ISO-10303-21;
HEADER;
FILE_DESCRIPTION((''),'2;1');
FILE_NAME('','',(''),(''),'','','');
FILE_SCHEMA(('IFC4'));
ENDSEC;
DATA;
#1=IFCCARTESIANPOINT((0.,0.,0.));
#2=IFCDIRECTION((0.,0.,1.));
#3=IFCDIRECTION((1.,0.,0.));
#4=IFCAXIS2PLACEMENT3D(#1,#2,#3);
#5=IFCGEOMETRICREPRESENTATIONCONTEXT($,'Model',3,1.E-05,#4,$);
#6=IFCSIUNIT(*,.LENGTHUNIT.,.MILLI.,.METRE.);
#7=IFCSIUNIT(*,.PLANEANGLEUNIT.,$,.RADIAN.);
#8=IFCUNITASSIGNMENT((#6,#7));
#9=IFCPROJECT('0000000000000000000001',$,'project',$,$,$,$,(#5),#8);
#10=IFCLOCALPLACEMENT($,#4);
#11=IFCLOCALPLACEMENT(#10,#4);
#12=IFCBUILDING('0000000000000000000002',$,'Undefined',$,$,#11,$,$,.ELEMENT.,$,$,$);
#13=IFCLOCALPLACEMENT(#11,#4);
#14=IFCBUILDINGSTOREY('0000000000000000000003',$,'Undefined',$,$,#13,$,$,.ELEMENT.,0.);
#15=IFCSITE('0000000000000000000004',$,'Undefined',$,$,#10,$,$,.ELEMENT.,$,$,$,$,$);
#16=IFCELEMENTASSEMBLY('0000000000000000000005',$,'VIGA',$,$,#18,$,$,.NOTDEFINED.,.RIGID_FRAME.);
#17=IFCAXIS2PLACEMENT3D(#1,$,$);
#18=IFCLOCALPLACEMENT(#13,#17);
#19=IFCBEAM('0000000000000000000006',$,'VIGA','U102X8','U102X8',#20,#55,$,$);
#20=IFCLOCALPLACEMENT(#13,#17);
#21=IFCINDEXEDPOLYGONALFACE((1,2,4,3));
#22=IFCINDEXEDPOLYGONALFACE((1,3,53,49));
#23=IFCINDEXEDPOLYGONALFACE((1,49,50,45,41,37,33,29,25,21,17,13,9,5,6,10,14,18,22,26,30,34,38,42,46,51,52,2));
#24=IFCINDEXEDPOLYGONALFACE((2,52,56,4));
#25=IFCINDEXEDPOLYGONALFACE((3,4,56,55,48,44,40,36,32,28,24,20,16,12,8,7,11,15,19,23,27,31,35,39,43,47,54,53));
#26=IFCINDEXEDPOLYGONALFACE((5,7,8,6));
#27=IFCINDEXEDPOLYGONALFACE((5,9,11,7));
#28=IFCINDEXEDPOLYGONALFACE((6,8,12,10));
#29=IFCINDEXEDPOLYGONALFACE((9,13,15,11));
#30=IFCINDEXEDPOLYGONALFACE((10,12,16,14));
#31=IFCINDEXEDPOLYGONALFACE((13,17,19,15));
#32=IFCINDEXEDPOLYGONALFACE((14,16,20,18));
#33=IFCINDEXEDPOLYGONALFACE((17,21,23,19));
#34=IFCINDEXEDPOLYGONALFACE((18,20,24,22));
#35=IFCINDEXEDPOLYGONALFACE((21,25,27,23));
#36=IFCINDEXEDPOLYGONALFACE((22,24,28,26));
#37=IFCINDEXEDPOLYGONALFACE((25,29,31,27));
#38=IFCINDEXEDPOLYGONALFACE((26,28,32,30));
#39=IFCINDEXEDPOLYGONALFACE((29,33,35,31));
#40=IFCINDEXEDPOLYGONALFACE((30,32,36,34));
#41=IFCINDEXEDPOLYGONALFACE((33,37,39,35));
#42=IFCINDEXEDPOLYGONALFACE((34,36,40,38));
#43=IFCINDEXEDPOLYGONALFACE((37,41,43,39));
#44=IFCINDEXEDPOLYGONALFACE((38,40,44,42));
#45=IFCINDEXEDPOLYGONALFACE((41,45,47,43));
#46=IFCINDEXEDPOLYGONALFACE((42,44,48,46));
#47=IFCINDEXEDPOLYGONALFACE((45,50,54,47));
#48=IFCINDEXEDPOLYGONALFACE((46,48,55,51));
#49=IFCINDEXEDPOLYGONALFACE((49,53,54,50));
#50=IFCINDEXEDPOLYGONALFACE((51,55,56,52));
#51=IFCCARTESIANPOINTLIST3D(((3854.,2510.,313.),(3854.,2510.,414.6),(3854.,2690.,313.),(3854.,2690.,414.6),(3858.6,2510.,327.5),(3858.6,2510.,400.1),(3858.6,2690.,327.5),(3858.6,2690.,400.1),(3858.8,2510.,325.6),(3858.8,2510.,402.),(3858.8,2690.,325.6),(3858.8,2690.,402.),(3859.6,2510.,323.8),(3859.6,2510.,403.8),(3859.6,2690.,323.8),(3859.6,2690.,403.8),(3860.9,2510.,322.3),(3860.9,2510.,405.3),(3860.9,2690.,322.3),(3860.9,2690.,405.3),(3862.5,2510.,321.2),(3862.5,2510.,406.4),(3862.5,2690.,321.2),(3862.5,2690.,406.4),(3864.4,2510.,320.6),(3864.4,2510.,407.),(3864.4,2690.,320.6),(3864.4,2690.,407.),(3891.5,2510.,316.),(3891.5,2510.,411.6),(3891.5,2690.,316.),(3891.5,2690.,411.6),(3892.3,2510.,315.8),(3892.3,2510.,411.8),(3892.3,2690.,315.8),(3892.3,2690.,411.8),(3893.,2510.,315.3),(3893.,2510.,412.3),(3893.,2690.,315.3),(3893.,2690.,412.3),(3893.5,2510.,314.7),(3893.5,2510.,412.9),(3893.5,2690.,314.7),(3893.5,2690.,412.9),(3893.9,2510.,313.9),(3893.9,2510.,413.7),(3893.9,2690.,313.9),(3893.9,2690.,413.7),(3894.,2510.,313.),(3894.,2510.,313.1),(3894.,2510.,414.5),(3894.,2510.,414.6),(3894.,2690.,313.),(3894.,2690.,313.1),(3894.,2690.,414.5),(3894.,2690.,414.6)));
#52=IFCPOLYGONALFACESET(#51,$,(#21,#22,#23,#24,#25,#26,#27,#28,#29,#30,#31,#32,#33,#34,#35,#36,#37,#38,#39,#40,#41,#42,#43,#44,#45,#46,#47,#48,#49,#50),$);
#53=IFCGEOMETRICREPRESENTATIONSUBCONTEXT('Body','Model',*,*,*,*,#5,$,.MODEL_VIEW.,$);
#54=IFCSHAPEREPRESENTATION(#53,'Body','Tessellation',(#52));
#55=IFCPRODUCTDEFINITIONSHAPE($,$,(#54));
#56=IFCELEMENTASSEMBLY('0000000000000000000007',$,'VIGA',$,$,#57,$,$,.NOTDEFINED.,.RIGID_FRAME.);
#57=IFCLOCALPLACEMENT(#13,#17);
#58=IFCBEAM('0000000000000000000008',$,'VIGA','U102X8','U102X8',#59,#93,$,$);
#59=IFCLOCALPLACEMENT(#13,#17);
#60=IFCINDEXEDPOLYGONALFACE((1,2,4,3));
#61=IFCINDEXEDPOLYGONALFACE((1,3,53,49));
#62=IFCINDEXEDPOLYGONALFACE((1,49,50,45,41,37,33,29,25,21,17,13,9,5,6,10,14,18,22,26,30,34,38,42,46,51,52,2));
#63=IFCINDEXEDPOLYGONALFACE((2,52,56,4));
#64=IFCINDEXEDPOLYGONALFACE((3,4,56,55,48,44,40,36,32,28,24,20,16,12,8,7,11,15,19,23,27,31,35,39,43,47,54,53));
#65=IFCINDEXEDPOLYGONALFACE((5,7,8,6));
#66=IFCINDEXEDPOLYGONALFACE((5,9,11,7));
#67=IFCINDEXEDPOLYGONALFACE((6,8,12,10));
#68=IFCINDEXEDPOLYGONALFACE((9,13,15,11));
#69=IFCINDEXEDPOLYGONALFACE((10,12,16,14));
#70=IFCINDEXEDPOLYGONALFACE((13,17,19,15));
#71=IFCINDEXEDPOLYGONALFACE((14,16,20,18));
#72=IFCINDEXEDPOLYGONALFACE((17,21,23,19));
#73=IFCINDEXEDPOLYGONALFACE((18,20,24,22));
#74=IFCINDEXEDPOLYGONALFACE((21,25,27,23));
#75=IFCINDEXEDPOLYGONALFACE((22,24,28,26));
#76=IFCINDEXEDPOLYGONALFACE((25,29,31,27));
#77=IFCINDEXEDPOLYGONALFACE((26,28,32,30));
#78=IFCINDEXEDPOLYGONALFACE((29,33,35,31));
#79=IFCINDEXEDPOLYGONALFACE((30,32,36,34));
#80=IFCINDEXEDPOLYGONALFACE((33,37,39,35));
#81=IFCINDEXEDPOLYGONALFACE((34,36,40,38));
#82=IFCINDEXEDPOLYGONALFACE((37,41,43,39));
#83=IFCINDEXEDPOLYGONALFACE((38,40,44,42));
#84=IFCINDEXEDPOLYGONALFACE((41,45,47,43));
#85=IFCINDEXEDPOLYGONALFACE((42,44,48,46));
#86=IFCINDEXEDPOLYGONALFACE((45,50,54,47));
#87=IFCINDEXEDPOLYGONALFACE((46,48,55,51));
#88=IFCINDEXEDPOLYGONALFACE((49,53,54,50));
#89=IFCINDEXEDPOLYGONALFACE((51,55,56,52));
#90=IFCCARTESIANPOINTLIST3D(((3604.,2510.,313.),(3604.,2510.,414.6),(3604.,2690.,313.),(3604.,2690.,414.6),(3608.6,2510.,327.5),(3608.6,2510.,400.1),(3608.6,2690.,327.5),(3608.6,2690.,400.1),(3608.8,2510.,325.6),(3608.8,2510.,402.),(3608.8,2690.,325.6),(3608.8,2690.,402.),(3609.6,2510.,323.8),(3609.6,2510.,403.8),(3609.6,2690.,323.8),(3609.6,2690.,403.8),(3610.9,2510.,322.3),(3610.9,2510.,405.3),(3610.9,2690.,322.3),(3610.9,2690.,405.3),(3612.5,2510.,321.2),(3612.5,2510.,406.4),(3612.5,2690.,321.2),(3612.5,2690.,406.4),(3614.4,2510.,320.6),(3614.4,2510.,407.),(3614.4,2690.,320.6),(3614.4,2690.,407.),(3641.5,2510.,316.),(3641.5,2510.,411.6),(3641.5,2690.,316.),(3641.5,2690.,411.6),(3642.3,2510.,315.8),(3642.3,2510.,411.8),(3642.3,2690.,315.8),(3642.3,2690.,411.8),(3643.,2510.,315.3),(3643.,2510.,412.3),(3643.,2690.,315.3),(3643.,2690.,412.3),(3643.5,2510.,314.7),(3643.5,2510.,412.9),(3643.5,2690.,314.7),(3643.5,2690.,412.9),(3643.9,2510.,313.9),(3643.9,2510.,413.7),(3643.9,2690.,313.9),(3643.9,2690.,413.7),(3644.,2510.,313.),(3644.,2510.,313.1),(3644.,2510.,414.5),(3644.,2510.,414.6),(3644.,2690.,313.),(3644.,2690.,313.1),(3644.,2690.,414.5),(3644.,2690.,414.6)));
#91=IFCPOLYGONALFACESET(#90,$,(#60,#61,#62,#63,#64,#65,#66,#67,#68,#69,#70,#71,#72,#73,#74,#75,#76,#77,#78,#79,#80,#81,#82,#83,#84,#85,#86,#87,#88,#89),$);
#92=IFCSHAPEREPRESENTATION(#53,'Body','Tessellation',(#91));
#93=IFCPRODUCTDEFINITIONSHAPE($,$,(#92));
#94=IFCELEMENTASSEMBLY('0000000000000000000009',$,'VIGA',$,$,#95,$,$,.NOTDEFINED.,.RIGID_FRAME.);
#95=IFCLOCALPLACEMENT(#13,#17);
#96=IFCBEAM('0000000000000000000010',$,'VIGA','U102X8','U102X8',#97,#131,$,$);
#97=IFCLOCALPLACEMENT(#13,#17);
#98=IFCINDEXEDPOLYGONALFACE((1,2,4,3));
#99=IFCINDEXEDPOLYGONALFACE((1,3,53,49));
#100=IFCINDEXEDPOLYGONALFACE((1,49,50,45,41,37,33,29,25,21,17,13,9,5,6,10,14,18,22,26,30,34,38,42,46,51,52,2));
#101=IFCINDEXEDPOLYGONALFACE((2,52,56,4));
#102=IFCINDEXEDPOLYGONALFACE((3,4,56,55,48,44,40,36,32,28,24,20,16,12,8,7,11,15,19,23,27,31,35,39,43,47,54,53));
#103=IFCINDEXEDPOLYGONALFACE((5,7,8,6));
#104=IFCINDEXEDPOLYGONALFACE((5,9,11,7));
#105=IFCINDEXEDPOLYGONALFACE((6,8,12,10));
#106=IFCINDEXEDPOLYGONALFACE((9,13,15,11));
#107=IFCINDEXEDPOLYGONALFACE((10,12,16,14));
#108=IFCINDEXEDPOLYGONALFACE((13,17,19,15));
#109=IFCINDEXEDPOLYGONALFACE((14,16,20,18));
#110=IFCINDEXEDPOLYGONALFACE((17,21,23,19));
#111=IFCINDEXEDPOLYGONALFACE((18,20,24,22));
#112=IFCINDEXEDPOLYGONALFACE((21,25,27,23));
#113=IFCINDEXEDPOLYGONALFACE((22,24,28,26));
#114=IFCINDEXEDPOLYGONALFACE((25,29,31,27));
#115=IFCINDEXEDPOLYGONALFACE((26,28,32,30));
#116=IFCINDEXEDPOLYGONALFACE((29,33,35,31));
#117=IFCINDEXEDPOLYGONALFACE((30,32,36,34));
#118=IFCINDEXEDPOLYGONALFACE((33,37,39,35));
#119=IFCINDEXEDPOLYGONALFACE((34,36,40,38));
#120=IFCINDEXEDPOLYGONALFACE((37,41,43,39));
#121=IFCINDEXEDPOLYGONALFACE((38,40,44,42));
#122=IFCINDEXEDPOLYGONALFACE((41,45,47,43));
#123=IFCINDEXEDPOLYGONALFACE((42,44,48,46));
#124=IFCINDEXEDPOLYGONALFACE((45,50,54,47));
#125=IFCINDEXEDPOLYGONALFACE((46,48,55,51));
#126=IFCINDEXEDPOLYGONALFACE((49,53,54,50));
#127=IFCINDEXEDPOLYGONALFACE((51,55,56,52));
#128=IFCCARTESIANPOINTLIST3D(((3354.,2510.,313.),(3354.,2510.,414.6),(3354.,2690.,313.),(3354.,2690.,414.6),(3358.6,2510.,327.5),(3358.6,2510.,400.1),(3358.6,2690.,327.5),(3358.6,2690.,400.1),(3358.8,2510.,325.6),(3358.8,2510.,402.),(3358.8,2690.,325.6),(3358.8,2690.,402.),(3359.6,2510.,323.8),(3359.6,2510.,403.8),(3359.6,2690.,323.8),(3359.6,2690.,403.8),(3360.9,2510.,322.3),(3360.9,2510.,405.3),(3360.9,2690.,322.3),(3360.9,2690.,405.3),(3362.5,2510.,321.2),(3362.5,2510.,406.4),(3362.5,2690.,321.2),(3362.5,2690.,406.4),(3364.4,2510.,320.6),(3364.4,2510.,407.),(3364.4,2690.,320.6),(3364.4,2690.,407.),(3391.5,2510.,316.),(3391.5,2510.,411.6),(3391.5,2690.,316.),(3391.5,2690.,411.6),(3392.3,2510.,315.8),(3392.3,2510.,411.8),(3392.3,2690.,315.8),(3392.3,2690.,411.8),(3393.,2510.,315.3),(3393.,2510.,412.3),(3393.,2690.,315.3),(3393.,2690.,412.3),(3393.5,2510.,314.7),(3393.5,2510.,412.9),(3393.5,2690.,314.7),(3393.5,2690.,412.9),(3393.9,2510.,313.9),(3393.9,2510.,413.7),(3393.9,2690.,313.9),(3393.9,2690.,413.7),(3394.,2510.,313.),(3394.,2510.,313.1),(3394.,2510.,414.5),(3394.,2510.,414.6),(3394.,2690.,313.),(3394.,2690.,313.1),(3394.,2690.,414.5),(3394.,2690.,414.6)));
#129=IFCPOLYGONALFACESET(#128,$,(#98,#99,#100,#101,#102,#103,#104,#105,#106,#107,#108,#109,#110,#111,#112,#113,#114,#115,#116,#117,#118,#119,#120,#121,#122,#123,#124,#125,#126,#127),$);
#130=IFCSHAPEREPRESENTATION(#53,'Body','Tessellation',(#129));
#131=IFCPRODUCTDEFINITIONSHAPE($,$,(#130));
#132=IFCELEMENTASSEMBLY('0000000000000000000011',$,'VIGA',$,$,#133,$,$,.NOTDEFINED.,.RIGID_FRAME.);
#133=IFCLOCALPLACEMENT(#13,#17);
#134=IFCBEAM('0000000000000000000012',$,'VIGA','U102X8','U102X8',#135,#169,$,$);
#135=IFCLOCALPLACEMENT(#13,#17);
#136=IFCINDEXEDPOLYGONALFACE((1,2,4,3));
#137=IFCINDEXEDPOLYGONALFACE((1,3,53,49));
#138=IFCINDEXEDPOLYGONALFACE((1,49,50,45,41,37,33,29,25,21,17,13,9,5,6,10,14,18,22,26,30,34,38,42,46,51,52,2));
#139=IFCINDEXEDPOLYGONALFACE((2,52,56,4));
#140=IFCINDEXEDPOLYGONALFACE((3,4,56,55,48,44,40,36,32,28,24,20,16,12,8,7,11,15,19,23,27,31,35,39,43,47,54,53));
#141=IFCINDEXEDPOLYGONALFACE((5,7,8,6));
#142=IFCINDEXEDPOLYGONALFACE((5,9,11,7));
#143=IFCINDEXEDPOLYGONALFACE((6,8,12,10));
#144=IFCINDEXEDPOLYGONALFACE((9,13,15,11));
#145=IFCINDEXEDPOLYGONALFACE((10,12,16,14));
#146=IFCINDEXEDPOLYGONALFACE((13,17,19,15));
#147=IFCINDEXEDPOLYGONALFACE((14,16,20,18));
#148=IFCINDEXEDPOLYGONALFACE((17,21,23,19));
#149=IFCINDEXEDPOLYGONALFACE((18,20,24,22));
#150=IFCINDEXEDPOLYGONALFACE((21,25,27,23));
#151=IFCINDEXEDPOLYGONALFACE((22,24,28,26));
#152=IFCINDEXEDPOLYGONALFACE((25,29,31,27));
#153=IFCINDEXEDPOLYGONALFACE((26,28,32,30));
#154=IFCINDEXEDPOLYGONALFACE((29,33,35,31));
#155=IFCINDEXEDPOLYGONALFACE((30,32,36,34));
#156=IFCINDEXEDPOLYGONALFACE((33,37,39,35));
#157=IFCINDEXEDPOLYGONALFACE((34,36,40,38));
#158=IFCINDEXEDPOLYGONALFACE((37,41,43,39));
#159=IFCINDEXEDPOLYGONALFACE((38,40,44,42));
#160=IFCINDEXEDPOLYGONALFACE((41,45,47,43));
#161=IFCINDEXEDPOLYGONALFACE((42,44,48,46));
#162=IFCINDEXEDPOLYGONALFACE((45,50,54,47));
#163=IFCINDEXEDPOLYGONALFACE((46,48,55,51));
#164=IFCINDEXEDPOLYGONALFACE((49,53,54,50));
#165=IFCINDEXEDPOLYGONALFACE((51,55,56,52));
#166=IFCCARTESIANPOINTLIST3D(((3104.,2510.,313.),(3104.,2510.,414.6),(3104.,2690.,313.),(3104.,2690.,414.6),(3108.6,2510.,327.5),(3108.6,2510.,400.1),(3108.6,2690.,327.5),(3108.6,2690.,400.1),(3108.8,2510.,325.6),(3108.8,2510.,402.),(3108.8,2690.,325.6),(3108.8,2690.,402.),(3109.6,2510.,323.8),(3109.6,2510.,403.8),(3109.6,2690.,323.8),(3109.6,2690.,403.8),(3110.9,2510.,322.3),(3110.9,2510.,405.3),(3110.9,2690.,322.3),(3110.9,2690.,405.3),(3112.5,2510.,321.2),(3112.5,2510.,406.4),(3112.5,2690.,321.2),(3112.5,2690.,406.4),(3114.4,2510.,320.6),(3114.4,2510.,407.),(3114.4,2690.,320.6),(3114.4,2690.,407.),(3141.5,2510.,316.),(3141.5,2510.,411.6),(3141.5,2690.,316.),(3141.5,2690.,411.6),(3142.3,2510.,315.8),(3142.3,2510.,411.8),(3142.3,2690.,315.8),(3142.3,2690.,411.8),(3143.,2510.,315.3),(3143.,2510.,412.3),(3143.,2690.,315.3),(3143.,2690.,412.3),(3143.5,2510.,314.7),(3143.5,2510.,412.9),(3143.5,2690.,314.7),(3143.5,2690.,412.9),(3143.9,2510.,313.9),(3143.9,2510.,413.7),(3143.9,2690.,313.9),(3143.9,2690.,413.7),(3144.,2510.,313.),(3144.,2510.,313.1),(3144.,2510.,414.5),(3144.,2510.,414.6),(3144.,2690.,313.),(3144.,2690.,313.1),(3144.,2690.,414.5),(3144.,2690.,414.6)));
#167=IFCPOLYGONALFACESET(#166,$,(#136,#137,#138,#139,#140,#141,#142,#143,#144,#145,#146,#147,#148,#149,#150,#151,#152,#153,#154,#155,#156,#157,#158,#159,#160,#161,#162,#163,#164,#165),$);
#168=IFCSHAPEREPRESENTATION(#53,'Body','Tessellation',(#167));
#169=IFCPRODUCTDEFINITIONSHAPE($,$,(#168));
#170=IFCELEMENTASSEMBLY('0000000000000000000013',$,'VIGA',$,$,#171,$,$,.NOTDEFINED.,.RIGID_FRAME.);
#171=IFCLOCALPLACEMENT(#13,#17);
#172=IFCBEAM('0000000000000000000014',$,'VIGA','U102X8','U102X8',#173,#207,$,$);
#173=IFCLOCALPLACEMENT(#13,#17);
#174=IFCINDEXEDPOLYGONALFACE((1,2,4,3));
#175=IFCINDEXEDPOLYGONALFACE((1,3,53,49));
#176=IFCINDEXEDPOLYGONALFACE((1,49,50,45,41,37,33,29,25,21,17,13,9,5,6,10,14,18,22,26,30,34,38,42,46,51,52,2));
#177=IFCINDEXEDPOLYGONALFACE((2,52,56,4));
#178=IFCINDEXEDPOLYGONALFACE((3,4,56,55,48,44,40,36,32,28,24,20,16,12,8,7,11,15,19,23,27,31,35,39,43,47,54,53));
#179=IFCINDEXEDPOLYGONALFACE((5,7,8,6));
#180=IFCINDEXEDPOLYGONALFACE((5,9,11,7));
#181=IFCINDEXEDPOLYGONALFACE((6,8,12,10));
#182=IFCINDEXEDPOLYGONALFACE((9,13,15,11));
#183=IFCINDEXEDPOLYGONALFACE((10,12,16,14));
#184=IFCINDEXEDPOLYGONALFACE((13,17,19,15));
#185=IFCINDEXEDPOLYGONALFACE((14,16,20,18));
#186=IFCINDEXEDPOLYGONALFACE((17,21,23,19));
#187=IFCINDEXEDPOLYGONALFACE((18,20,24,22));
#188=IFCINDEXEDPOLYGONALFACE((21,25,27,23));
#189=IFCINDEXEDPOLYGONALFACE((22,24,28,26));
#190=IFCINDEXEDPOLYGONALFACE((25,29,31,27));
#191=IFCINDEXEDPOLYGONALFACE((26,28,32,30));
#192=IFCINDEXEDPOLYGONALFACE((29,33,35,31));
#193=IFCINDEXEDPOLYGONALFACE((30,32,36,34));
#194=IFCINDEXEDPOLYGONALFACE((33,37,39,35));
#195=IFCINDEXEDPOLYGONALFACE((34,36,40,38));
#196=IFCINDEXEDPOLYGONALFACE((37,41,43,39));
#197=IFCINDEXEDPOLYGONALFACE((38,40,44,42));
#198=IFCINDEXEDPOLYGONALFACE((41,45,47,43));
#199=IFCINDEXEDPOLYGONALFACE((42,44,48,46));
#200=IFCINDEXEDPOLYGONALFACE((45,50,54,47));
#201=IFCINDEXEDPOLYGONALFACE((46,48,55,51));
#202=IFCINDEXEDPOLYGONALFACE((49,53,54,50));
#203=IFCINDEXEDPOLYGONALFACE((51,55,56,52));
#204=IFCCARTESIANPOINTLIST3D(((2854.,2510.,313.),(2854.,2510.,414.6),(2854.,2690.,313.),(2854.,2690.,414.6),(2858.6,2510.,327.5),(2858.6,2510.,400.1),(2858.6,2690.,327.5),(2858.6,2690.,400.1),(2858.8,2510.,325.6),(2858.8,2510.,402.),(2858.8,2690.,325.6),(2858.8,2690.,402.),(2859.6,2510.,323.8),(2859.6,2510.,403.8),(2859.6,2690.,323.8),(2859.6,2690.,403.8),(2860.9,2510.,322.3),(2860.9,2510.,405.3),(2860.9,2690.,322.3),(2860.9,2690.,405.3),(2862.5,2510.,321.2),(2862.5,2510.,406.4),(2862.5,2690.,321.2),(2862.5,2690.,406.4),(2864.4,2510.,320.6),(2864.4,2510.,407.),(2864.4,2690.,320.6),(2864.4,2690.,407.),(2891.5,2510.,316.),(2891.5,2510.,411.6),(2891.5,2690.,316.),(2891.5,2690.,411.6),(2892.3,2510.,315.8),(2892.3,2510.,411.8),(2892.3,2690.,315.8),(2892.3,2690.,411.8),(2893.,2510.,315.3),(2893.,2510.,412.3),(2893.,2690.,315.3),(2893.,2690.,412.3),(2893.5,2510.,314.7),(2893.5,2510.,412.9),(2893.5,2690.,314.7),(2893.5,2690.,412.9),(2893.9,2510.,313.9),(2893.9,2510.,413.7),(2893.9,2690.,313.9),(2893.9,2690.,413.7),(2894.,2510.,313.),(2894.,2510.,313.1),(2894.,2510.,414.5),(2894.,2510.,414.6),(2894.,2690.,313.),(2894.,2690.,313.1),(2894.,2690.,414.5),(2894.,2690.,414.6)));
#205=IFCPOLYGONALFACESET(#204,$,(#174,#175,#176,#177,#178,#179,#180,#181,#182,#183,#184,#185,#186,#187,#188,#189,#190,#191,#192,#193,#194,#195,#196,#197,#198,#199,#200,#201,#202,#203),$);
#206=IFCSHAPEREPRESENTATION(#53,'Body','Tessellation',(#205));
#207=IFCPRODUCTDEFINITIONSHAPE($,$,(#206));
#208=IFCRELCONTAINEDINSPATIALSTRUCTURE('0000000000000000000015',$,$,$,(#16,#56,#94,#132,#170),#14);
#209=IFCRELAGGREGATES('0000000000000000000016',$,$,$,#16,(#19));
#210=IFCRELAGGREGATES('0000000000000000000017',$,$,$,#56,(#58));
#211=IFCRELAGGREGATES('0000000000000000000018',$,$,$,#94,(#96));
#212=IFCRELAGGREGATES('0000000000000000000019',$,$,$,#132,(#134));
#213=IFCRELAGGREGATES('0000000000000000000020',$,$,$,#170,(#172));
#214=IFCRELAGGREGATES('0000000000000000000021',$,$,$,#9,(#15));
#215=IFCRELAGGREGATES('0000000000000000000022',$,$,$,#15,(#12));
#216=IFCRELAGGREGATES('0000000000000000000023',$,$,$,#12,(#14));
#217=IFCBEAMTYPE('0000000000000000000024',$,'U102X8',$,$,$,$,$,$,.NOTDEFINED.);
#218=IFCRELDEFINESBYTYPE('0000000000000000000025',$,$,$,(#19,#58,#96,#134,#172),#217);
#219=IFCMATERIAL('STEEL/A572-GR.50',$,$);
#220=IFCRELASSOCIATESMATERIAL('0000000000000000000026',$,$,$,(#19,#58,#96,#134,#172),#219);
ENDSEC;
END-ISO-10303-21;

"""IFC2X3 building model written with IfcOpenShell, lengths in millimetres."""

from ifc_helpers import new_model, si_unit, frame, origin_with_axes, origin_2d_with_axis, place, context, subcontext, project, spatial, u_section, extrude, material, type_object, element, aggregate, save


model = new_model("IFC2X3")

# Units and contexts
model_context = context("Model", 3, precision=1e-05, world=origin_with_axes())
body_context = subcontext(model_context, "Body", "Model", "MODEL_VIEW")
ifc_project = project(units=[si_unit("LENGTHUNIT", "METRE", prefix="MILLI"), si_unit("PLANEANGLEUNIT", "RADIAN")], contexts=[model_context])

# Site, building, storey
site_placement = place(None, origin_with_axes())
site = spatial("IfcSite", under=ifc_project, at=site_placement, Name="Undefined", CompositionType="ELEMENT")
building_placement = place(site_placement, origin_with_axes())
building = spatial("IfcBuilding", under=site, at=building_placement, Name="Undefined", CompositionType="ELEMENT")
storey_placement = place(building_placement, origin_with_axes())
storey = spatial("IfcBuildingStorey", under=building, at=storey_placement, Name="Undefined", CompositionType="ELEMENT", Elevation=0.0)

# Element assemblies, beams
ifc_material = material(Name="STEEL/A572-GR.50")
beam_type = type_object("IfcBeamType", Name="U102X8", PredefinedType="NOTDEFINED")
assembly_1_placement = place(storey_placement, origin_with_axes())
assembly_1 = element("IfcElementAssembly", 1, at=assembly_1_placement, inside=storey, Name="VIGA", AssemblyPlace="NOTDEFINED", PredefinedType="RIGID_FRAME")
beam_1_placement = place(assembly_1_placement, frame((3874.0, 2510.0, 363.8), z_axis=(0.0, 0.0, 1.0), x_axis=(0.0, 1.0, 0.0)))
beam_1 = element("IfcBeam", 2, at=beam_1_placement, type_object=beam_type, material=ifc_material, Name="VIGA", Description="U102X8", ObjectType="U102X8", context=body_context, shape_type="SweptSolid", body=[
    extrude(u_section(Depth=101.6, FlangeWidth=40.0, WebThickness=4.6, FlangeThickness=6.0, FilletRadius=7.0, EdgeRadius=3.0, FlangeSlope=0.16839, at=origin_2d_with_axis()), frame((180.0, 0.0, 0.0), z_axis=(-1.0, 0.0, 0.0), x_axis=(0.0, -1.0, 0.0)), (0.0, 0.0, 1.0), 180.0),
])
aggregate(assembly_1, [beam_1])
assembly_2_placement = place(storey_placement, origin_with_axes())
assembly_2 = element("IfcElementAssembly", 3, at=assembly_2_placement, inside=storey, Name="VIGA", AssemblyPlace="NOTDEFINED", PredefinedType="RIGID_FRAME")
beam_2_placement = place(assembly_2_placement, frame((3624.0, 2510.0, 363.8), z_axis=(0.0, 0.0, 1.0), x_axis=(0.0, 1.0, 0.0)))
beam_2 = element("IfcBeam", 4, at=beam_2_placement, type_object=beam_type, material=ifc_material, Name="VIGA", Description="U102X8", ObjectType="U102X8", context=body_context, shape_type="SweptSolid", body=[
    extrude(u_section(Depth=101.6, FlangeWidth=40.0, WebThickness=4.6, FlangeThickness=6.0, FilletRadius=7.0, EdgeRadius=3.0, FlangeSlope=0.16839, at=origin_2d_with_axis()), frame((180.0, 0.0, 0.0), z_axis=(-1.0, 0.0, 0.0), x_axis=(0.0, -1.0, 0.0)), (0.0, 0.0, 1.0), 180.0),
])
aggregate(assembly_2, [beam_2])
assembly_3_placement = place(storey_placement, origin_with_axes())
assembly_3 = element("IfcElementAssembly", 5, at=assembly_3_placement, inside=storey, Name="VIGA", AssemblyPlace="NOTDEFINED", PredefinedType="RIGID_FRAME")
beam_3_placement = place(assembly_3_placement, frame((3374.0, 2510.0, 363.8), z_axis=(0.0, 0.0, 1.0), x_axis=(0.0, 1.0, 0.0)))
beam_3 = element("IfcBeam", 6, at=beam_3_placement, type_object=beam_type, material=ifc_material, Name="VIGA", Description="U102X8", ObjectType="U102X8", context=body_context, shape_type="SweptSolid", body=[
    extrude(u_section(Depth=101.6, FlangeWidth=40.0, WebThickness=4.6, FlangeThickness=6.0, FilletRadius=7.0, EdgeRadius=3.0, FlangeSlope=0.16839, at=origin_2d_with_axis()), frame((180.0, 0.0, 0.0), z_axis=(-1.0, 0.0, 0.0), x_axis=(0.0, -1.0, 0.0)), (0.0, 0.0, 1.0), 180.0),
])
aggregate(assembly_3, [beam_3])
assembly_4_placement = place(storey_placement, origin_with_axes())
assembly_4 = element("IfcElementAssembly", 7, at=assembly_4_placement, inside=storey, Name="VIGA", AssemblyPlace="NOTDEFINED", PredefinedType="RIGID_FRAME")
beam_4_placement = place(assembly_4_placement, frame((3124.0, 2510.0, 363.8), z_axis=(0.0, 0.0, 1.0), x_axis=(0.0, 1.0, 0.0)))
beam_4 = element("IfcBeam", 8, at=beam_4_placement, type_object=beam_type, material=ifc_material, Name="VIGA", Description="U102X8", ObjectType="U102X8", context=body_context, shape_type="SweptSolid", body=[
    extrude(u_section(Depth=101.6, FlangeWidth=40.0, WebThickness=4.6, FlangeThickness=6.0, FilletRadius=7.0, EdgeRadius=3.0, FlangeSlope=0.16839, at=origin_2d_with_axis()), frame((180.0, 0.0, 0.0), z_axis=(-1.0, 0.0, 0.0), x_axis=(0.0, -1.0, 0.0)), (0.0, 0.0, 1.0), 180.0),
])
aggregate(assembly_4, [beam_4])
assembly_5_placement = place(storey_placement, origin_with_axes())
assembly_5 = element("IfcElementAssembly", 9, at=assembly_5_placement, inside=storey, Name="VIGA", AssemblyPlace="NOTDEFINED", PredefinedType="RIGID_FRAME")
beam_5_placement = place(assembly_5_placement, frame((2874.0, 2510.0, 363.8), z_axis=(0.0, 0.0, 1.0), x_axis=(0.0, 1.0, 0.0)))
beam_5 = element("IfcBeam", 10, at=beam_5_placement, type_object=beam_type, material=ifc_material, Name="VIGA", Description="U102X8", ObjectType="U102X8", context=body_context, shape_type="SweptSolid", body=[
    extrude(u_section(Depth=101.6, FlangeWidth=40.0, WebThickness=4.6, FlangeThickness=6.0, FilletRadius=7.0, EdgeRadius=3.0, FlangeSlope=0.16839, at=origin_2d_with_axis()), frame((180.0, 0.0, 0.0), z_axis=(-1.0, 0.0, 0.0), x_axis=(0.0, -1.0, 0.0)), (0.0, 0.0, 1.0), 180.0),
])
aggregate(assembly_5, [beam_5])

save(model, "model.ifc")
